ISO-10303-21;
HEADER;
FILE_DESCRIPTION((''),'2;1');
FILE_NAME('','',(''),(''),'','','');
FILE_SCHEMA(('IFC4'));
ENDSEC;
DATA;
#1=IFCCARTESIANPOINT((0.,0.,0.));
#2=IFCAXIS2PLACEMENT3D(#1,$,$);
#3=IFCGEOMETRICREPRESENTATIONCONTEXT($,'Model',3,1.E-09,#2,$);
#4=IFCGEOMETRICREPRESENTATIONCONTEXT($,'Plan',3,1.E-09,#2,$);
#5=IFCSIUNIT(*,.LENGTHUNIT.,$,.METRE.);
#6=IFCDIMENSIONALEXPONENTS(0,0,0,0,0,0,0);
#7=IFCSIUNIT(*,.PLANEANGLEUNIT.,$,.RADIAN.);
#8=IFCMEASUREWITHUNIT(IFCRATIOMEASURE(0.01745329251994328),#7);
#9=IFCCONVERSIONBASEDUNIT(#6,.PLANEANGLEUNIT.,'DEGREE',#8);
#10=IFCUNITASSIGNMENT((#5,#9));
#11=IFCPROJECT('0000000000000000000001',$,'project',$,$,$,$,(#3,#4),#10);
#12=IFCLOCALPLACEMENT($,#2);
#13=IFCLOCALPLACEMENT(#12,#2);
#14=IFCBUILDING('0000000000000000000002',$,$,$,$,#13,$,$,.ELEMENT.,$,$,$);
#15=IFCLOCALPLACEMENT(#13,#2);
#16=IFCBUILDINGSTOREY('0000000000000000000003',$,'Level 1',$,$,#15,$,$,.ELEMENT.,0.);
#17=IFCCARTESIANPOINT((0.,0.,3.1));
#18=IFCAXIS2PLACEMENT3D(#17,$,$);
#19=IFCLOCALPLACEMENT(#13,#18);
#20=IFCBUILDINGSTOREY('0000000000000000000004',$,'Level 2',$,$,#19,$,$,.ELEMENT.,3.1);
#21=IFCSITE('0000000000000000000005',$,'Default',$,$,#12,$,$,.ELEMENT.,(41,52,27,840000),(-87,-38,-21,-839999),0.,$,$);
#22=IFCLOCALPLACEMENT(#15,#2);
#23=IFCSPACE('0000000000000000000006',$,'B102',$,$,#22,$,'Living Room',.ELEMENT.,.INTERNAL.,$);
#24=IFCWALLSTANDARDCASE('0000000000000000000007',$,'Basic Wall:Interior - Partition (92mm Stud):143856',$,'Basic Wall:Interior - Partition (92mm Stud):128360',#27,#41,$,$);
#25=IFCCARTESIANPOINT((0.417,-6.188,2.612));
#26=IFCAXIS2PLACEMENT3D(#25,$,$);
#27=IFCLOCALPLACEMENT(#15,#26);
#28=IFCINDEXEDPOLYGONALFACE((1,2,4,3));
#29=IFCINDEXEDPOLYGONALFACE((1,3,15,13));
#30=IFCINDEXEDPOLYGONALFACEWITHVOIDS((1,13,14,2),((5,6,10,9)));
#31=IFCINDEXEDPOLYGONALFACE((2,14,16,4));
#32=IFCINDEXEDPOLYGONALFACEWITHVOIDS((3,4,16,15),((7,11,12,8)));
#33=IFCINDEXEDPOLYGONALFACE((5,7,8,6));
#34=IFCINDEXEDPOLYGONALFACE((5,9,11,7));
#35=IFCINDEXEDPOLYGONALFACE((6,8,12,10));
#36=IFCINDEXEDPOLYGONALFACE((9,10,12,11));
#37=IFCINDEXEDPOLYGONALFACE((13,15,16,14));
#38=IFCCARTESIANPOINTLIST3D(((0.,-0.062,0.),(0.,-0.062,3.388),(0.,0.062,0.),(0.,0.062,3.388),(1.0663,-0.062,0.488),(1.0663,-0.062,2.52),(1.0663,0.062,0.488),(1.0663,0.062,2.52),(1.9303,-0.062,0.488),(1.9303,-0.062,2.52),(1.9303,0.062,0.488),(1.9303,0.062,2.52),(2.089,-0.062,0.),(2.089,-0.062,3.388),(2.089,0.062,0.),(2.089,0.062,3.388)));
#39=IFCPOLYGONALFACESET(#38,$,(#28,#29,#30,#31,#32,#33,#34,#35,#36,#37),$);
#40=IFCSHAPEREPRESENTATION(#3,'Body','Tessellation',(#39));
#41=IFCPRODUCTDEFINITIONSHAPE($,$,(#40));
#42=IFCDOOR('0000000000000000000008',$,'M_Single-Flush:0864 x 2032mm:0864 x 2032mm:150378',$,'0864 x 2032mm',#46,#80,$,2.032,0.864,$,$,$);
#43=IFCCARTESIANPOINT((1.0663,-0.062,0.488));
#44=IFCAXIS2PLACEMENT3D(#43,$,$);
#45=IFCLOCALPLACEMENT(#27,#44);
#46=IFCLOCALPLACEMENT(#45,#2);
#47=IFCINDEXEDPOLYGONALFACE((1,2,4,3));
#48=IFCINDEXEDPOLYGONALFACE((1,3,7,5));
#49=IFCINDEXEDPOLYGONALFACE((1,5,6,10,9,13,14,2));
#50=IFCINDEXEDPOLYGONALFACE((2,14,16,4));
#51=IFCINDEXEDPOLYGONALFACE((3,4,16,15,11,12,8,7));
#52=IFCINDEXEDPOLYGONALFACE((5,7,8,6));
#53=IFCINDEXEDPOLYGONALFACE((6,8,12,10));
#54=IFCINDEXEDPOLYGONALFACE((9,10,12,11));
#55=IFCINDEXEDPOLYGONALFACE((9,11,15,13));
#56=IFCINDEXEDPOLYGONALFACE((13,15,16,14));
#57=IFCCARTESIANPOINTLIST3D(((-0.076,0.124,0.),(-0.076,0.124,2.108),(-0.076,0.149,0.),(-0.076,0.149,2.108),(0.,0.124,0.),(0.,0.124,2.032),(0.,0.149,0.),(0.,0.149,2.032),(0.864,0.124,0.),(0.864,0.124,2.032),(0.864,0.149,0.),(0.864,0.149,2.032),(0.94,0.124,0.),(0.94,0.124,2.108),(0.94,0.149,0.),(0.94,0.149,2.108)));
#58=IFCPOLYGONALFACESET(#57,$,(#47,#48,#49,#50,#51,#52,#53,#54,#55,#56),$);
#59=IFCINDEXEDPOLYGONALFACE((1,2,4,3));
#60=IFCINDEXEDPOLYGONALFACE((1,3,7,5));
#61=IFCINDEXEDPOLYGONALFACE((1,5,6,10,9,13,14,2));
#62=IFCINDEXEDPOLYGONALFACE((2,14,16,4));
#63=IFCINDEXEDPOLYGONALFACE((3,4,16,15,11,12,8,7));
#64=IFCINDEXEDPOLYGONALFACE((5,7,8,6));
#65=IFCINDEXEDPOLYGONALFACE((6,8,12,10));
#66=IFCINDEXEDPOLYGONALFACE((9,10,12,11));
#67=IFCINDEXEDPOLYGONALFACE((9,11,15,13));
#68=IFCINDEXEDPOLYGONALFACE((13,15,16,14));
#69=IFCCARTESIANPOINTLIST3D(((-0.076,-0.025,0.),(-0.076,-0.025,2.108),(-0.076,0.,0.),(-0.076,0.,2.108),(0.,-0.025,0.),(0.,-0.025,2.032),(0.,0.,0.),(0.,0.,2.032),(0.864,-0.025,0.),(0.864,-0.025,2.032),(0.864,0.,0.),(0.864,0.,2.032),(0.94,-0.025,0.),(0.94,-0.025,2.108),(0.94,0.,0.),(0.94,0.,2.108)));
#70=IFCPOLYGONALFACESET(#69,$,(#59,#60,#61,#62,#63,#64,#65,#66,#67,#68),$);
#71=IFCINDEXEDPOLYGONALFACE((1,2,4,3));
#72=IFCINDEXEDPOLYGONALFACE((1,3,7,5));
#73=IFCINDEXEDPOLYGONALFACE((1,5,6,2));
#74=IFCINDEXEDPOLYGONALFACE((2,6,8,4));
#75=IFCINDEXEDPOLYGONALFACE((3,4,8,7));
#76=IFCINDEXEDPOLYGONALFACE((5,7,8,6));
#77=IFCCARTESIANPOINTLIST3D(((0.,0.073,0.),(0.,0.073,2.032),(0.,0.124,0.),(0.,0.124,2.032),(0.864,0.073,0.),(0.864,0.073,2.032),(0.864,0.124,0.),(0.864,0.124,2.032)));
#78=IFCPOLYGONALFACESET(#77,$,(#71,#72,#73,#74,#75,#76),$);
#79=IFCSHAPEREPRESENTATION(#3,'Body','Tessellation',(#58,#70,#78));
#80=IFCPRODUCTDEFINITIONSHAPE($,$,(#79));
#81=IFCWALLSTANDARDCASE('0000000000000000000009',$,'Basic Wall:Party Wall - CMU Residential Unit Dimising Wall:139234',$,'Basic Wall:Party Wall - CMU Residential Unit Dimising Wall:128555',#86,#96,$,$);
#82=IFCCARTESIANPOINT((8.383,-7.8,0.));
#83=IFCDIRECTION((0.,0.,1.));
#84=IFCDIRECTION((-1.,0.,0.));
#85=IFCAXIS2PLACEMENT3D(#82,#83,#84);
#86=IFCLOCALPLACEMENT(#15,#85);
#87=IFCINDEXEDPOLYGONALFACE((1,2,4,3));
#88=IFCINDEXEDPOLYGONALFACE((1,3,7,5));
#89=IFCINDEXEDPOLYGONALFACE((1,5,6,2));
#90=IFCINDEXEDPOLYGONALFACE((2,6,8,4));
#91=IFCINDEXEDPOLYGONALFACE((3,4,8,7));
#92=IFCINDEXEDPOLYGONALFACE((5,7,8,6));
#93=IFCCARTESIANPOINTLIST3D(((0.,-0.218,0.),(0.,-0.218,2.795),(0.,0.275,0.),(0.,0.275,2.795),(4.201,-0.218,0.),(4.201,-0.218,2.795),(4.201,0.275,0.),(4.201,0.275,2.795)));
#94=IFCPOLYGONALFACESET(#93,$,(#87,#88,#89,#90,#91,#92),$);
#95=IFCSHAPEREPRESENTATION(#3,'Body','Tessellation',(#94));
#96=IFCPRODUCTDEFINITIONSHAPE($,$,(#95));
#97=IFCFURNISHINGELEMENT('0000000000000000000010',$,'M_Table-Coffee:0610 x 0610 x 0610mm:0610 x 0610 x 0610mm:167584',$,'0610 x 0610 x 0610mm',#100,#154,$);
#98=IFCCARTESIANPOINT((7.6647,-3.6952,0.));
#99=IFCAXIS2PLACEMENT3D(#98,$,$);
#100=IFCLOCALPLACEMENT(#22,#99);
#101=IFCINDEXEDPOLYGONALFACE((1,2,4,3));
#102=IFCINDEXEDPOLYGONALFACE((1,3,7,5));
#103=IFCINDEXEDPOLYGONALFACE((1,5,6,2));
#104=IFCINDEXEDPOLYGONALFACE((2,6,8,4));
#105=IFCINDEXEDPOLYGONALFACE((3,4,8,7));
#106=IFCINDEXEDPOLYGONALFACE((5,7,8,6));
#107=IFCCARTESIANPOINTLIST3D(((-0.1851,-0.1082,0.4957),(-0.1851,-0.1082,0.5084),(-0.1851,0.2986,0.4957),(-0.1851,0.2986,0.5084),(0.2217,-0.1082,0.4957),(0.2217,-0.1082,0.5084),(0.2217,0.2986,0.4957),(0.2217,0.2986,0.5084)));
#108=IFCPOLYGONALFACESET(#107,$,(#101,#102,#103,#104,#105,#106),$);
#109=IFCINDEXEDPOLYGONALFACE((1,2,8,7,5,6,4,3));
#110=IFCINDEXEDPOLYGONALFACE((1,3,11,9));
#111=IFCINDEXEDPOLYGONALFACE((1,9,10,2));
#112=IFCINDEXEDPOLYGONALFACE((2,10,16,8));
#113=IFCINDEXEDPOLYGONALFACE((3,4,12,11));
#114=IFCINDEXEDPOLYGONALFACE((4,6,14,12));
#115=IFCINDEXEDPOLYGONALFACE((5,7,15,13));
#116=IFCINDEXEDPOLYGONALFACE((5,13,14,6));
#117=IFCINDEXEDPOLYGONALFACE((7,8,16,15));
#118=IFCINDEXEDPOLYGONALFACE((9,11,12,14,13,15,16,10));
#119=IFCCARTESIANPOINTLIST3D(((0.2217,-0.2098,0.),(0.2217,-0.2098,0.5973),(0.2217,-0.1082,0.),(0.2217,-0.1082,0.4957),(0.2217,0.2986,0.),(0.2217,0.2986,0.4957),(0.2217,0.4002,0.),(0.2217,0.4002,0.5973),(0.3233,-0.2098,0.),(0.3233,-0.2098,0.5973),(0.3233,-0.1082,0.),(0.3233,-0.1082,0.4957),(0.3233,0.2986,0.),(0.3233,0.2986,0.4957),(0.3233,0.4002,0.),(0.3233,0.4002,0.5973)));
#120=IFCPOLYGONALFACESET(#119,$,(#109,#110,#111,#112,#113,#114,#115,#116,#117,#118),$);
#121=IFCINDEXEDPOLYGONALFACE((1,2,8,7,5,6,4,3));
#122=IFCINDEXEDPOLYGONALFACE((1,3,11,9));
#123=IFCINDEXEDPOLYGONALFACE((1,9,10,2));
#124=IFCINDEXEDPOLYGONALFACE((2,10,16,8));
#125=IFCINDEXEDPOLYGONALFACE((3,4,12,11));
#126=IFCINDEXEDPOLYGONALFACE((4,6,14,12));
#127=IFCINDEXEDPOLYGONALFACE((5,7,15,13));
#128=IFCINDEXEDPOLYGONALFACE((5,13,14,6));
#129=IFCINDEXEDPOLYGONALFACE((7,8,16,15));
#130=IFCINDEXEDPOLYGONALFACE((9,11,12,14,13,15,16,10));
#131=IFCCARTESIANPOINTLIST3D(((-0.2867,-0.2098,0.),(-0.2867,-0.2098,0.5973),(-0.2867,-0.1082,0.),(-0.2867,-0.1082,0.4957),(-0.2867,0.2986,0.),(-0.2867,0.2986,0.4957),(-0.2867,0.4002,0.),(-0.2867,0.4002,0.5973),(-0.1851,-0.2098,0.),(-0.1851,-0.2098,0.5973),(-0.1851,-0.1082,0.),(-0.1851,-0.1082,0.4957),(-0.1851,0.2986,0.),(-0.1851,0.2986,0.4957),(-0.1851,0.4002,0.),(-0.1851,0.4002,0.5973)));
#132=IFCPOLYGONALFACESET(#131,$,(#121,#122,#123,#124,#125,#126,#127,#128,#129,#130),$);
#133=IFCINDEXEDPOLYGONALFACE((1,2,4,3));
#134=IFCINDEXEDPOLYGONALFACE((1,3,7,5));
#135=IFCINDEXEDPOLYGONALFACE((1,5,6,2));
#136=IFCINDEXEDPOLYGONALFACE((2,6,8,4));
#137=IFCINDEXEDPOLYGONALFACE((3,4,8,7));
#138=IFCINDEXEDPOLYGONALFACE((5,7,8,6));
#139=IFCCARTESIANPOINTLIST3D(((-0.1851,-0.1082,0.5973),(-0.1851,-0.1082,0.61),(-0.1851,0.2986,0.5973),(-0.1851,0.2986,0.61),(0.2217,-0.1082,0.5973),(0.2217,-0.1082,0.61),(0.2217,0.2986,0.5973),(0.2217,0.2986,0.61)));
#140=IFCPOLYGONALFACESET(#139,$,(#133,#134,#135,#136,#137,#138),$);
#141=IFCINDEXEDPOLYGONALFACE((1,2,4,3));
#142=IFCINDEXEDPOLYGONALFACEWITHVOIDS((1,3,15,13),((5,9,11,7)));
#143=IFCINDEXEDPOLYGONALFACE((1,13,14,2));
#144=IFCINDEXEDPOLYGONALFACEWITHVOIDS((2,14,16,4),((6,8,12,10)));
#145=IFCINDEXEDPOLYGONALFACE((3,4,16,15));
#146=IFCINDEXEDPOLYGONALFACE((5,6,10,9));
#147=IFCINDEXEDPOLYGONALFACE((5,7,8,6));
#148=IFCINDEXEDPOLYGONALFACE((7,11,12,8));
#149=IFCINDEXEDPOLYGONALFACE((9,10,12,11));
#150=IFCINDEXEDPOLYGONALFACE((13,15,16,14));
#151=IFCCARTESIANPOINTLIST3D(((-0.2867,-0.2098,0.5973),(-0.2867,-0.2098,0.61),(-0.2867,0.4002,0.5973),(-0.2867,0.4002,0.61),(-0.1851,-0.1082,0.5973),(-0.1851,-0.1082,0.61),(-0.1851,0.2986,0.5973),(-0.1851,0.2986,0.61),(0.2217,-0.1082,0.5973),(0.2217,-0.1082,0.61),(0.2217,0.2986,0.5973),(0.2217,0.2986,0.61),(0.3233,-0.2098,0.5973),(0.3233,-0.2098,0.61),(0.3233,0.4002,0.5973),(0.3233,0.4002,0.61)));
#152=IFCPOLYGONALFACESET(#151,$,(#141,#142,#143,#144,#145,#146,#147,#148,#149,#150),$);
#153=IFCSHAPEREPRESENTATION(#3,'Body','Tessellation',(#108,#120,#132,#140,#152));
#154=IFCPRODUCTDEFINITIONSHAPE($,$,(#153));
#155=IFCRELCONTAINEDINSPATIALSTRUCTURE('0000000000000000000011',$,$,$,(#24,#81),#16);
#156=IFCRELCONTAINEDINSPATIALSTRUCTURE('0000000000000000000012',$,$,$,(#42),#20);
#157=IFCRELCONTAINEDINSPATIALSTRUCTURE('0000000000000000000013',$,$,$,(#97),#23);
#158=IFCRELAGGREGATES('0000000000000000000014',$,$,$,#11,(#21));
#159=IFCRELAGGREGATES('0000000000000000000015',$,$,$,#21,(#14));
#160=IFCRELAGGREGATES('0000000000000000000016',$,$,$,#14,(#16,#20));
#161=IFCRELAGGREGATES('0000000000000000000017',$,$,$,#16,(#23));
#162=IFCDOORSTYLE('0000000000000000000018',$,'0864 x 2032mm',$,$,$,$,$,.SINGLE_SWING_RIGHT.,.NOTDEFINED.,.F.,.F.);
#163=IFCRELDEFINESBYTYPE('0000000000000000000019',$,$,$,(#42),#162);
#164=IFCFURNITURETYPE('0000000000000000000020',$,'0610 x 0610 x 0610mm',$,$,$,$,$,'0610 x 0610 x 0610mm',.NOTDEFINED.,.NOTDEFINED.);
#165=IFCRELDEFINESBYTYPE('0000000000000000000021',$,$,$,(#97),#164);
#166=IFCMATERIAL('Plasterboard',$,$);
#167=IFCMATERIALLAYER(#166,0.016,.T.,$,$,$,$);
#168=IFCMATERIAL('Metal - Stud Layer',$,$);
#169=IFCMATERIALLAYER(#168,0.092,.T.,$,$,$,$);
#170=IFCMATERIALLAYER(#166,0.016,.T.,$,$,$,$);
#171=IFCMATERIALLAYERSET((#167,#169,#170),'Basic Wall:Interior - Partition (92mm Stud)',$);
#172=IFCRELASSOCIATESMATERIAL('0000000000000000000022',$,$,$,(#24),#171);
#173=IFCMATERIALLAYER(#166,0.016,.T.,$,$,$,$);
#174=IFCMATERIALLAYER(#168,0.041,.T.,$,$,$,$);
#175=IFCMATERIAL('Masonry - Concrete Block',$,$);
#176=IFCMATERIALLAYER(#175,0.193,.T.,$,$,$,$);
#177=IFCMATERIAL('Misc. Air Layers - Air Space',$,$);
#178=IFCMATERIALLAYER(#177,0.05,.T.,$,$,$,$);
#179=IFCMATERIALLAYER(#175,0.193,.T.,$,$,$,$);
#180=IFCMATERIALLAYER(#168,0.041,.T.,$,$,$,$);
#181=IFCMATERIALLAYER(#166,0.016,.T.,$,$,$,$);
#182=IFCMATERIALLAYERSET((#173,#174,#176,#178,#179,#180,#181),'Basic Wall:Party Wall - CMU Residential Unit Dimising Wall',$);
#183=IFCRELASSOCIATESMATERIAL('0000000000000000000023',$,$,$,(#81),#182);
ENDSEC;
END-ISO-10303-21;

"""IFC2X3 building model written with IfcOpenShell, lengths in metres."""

from ifc_helpers import new_model, entity, si_unit, converted_unit, frame, frame_2d, origin, origin_2d_with_axis, place, context, project, spatial, polyline, rectangle, outline, extrude, clip, bounded_halfspace, source, transform, mapped, material, layer, layer_set, layer_usage, type_object, type_shapes, element, fill, save


model = new_model("IFC2X3")

# Units and contexts
model_context = context("Model", 3, precision=1e-09, world=origin())
plan_context = context("Plan", 3, precision=1e-09, world=origin())
ifc_project = project(units=[si_unit("LENGTHUNIT", "METRE"), converted_unit("PLANEANGLEUNIT", "DEGREE", entity("IfcRatioMeasure", 0.01745329251994328), si_unit("PLANEANGLEUNIT", "RADIAN"), dimensions=[0, 0, 0, 0, 0, 0, 0])], contexts=[model_context, plan_context])

# Site, building, storey
site_placement = place(None, origin())
site = spatial("IfcSite", under=ifc_project, at=site_placement, Name="Default", CompositionType="ELEMENT", RefLatitude=(41, 52, 27, 840000), RefLongitude=(-87, -38, -21, -839999), RefElevation=0.0)
building_placement = place(site_placement, origin())
building = spatial("IfcBuilding", under=site, at=building_placement, CompositionType="ELEMENT")
storey_1_placement = place(building_placement, origin())
storey_1 = spatial("IfcBuildingStorey", under=building, at=storey_1_placement, Name="Level 1", CompositionType="ELEMENT", Elevation=0.0)

# Shared definitions
ifc_material_1 = material(Name="Misc. Air Layers - Air Space")
ifc_material_2 = material(Name="Masonry - Concrete Block")
ifc_material_3 = material(Name="Metal - Stud Layer")
ifc_material_4 = material(Name="Plasterboard")

# Shared definitions
ifc_layer_1 = layer(ifc_material_4, 0.016, ventilated=True)
ifc_layer_2 = layer(ifc_material_3, 0.092, ventilated=True)
ifc_layer_3 = layer(ifc_material_4, 0.016, ventilated=True)
ifc_layer_set_1 = layer_set([ifc_layer_1, ifc_layer_2, ifc_layer_3], Name="Basic Wall:Interior - Partition (92mm Stud)")
ifc_layer_usage_1 = layer_usage(ifc_layer_set_1, "AXIS2", "NEGATIVE", 0.062)

# Wall, opening
wall_1_placement = place(storey_1_placement, frame((0.417, -6.188, 2.612)))
wall_1 = element("IfcWallStandardCase", 1, at=wall_1_placement, inside=storey_1, material=ifc_layer_usage_1, Name="Basic Wall:Interior - Partition (92mm Stud):143856", ObjectType="Basic Wall:Interior - Partition (92mm Stud):128360", context=model_context, shape_type="SweptSolid", body=[
    extrude(rectangle(XDim=2.089, YDim=0.124, at=frame_2d((1.0445, 0.0), x_axis=(-1.0, 0.0))), origin(), (0.0, 0.0, 1.0), 3.388),
])
opening_1_placement = place(wall_1_placement, frame((1.0663, -0.062, 0.488)))
opening_1 = element("IfcOpeningElement", 2, at=opening_1_placement, cuts=wall_1, ObjectType="Opening", context=model_context, shape_type="SweptSolid", body=[
    extrude(rectangle(XDim=0.864, YDim=2.032, at=frame_2d((1.016, 0.432), x_axis=(0.0, 1.0))), frame((0.0, 0.0, 0.0), z_axis=(0.0, 1.0, 0.0), x_axis=(0.0, 0.0, 1.0)), (0.0, 0.0, 1.0), 0.124),
])

# Shared definitions
storey_2_placement = place(building_placement, frame((0.0, 0.0, 3.1)))
storey_2 = spatial("IfcBuildingStorey", under=building, at=storey_2_placement, Name="Level 2", CompositionType="ELEMENT", Elevation=3.1)

# Door
door_style_1 = type_object("IfcDoorStyle", Name="0864 x 2032mm", ConstructionType="NOTDEFINED", OperationType="SINGLE_SWING_RIGHT", ParameterTakesPrecedence=False, Sizeable=False)
shared_shape_1 = source(origin(), model_context, "Body", "SweptSolid", [
    extrude(outline(polyline([(-0.508, -1.073), (0.508, -1.073), (0.508, 1.035), (0.432, 1.035), (0.432, -0.997), (-0.432, -0.997), (-0.432, 1.035), (-0.508, 1.035), (-0.508, -1.073)])), frame((0.432, 0.124, 1.035), z_axis=(0.0, 1.0, 0.0), x_axis=(1.0, 0.0, 0.0)), (0.0, 0.0, 1.0), 0.025),
    extrude(outline(polyline([(-1.073, -0.508), (1.035, -0.508), (1.035, -0.432), (-0.997, -0.432), (-0.997, 0.432), (1.035, 0.432), (1.035, 0.508), (-1.073, 0.508), (-1.073, -0.508)])), frame((0.432, -0.025, 1.035), z_axis=(0.0, 1.0, 0.0), x_axis=(0.0, 0.0, -1.0)), (0.0, 0.0, 1.0), 0.025),
    extrude(rectangle(XDim=0.051, YDim=0.864, at=origin_2d_with_axis()), frame((0.432, 0.0985, 0.0), z_axis=(0.0, 0.0, 1.0), x_axis=(0.0, 1.0, 0.0)), (0.0, 0.0, 1.0), 2.032),
])
type_shapes(door_style_1, [shared_shape_1])
door_1_placement = place(opening_1_placement, origin())
door_1 = element("IfcDoor", 3, at=door_1_placement, inside=storey_2, type_object=door_style_1, Name="M_Single-Flush:0864 x 2032mm:0864 x 2032mm:150378", ObjectType="0864 x 2032mm", OverallHeight=2.032, OverallWidth=0.864, context=model_context, shape_type="MappedRepresentation", body=[
    mapped(shared_shape_1, transform((0.0, 0.0, 0.0), scale=1.0)),
])
fill(opening_1, door_1)

# Wall
ifc_layer_4 = layer(ifc_material_4, 0.016, ventilated=True)
ifc_layer_5 = layer(ifc_material_3, 0.041, ventilated=True)
ifc_layer_6 = layer(ifc_material_2, 0.193, ventilated=True)
ifc_layer_7 = layer(ifc_material_1, 0.05, ventilated=True)
ifc_layer_8 = layer(ifc_material_2, 0.193, ventilated=True)
ifc_layer_9 = layer(ifc_material_3, 0.041, ventilated=True)
ifc_layer_10 = layer(ifc_material_4, 0.016, ventilated=True)
ifc_layer_set_2 = layer_set([ifc_layer_4, ifc_layer_5, ifc_layer_6, ifc_layer_7, ifc_layer_8, ifc_layer_9, ifc_layer_10], Name="Basic Wall:Party Wall - CMU Residential Unit Dimising Wall")
ifc_layer_usage_2 = layer_usage(ifc_layer_set_2, "AXIS2", "NEGATIVE", 0.275)
wall_2_placement = place(storey_1_placement, frame((8.383, -7.8, 0.0), z_axis=(0.0, 0.0, 1.0), x_axis=(-1.0, 0.0, 0.0)))
element("IfcWallStandardCase", 4, at=wall_2_placement, inside=storey_1, material=ifc_layer_usage_2, Name="Basic Wall:Party Wall - CMU Residential Unit Dimising Wall:139234", ObjectType="Basic Wall:Party Wall - CMU Residential Unit Dimising Wall:128555", context=model_context, shape_type="Clipping", body=[
    clip(clip(extrude(rectangle(XDim=4.201, YDim=0.55, at=frame_2d((2.1005, 0.0), x_axis=(-1.0, 0.0))), origin(), (0.0, 0.0, 1.0), 2.795), bounded_halfspace(frame((0.0, -0.218, 2.795), z_axis=(0.0, 1.0, 0.0), x_axis=(-1.0, 0.0, 0.0)), True, frame((0.0, -0.218, 2.795), z_axis=(0.0, 1.0, 0.0), x_axis=(-1.0, 0.0, 0.0)), polyline([(0.0, 0.0), (-3.708, 0.0), (-4.201, 0.0), (-4.201, -2.795), (0.0, -2.795), (0.0, 0.0)]))), bounded_halfspace(frame((4.201, 0.275, 0.0), z_axis=(-1.0, 0.0, 0.0), x_axis=(0.0, -1.0, 0.0)), True, frame((4.201, 0.275, 0.0), z_axis=(-1.0, 0.0, 0.0), x_axis=(0.0, -1.0, 0.0)), polyline([(0.0, 0.0), (0.493, 0.0), (0.493, 2.795), (0.0, 2.795), (0.0, 0.0)]))),
])

# Shared definitions
space_1_placement = place(storey_1_placement, origin())
space_1 = spatial("IfcSpace", under=storey_1, at=space_1_placement, Name="B102", LongName="Living Room", CompositionType="ELEMENT", InteriorOrExteriorSpace="INTERNAL")

# Furnishing element
furniture_type_1 = type_object("IfcFurnitureType", Name="0610 x 0610 x 0610mm", ElementType="0610 x 0610 x 0610mm", AssemblyPlace="NOTDEFINED")
shared_shape_2 = source(origin(), model_context, "Body", "SweptSolid", [
    extrude(rectangle(XDim=0.4068, YDim=0.4068, at=origin_2d_with_axis()), frame((0.0183, 0.0952, 0.4957), z_axis=(0.0, 0.0, 1.0), x_axis=(-1.0, 0.0, 0.0)), (0.0, 0.0, 1.0), 0.0127),
    extrude(outline(polyline([(-0.2732, -0.305), (0.324, -0.305), (0.324, 0.305), (-0.2732, 0.305), (-0.2732, 0.2034), (0.2225, 0.2034), (0.2225, -0.2034), (-0.2732, -0.2034), (-0.2732, -0.305)])), frame((0.2217, 0.0952, 0.2732), z_axis=(1.0, 0.0, 0.0), x_axis=(0.0, 0.0, 1.0)), (0.0, 0.0, 1.0), 0.1016),
    extrude(outline(polyline([(-0.305, -0.3241), (0.305, -0.3241), (0.305, 0.2733), (0.2034, 0.2733), (0.2034, -0.2224), (-0.2034, -0.2224), (-0.2034, 0.2733), (-0.305, 0.2733), (-0.305, -0.3241)])), frame((-0.2867, 0.0952, 0.2733), z_axis=(1.0, 0.0, 0.0), x_axis=(0.0, -1.0, 0.0)), (0.0, 0.0, 1.0), 0.1016),
    extrude(rectangle(XDim=0.4068, YDim=0.4068, at=origin_2d_with_axis()), frame((0.0183, 0.0952, 0.5973), z_axis=(0.0, 0.0, 1.0), x_axis=(-1.0, 0.0, 0.0)), (0.0, 0.0, 1.0), 0.0127),
    extrude(outline(polyline([(-0.305, -0.305), (0.305, -0.305), (0.305, 0.305), (-0.305, 0.305), (-0.305, -0.305)]), holes=[polyline([(-0.2034, -0.2034), (-0.2034, 0.2034), (0.2034, 0.2034), (0.2034, -0.2034), (-0.2034, -0.2034)])]), frame((0.0183, 0.0952, 0.5973), z_axis=(0.0, 0.0, 1.0), x_axis=(-1.0, 0.0, 0.0)), (0.0, 0.0, 1.0), 0.0127),
])
type_shapes(furniture_type_1, [shared_shape_2])
for number, where, name in (
    (5, (7.6647, -3.6952, 0.0), "M_Table-Coffee:0610 x 0610 x 0610mm:0610 x 0610 x 0610mm:167584"),
):
    element("IfcFurnishingElement", number, at=place(space_1_placement, frame(where)), inside=space_1, type_object=furniture_type_1, Name=name, ObjectType="0610 x 0610 x 0610mm", context=model_context, shape_type="MappedRepresentation", body=[
        mapped(shared_shape_2, transform((0.0, 0.0, 0.0), scale=1.0)),
    ])

save(model, "model.ifc")
